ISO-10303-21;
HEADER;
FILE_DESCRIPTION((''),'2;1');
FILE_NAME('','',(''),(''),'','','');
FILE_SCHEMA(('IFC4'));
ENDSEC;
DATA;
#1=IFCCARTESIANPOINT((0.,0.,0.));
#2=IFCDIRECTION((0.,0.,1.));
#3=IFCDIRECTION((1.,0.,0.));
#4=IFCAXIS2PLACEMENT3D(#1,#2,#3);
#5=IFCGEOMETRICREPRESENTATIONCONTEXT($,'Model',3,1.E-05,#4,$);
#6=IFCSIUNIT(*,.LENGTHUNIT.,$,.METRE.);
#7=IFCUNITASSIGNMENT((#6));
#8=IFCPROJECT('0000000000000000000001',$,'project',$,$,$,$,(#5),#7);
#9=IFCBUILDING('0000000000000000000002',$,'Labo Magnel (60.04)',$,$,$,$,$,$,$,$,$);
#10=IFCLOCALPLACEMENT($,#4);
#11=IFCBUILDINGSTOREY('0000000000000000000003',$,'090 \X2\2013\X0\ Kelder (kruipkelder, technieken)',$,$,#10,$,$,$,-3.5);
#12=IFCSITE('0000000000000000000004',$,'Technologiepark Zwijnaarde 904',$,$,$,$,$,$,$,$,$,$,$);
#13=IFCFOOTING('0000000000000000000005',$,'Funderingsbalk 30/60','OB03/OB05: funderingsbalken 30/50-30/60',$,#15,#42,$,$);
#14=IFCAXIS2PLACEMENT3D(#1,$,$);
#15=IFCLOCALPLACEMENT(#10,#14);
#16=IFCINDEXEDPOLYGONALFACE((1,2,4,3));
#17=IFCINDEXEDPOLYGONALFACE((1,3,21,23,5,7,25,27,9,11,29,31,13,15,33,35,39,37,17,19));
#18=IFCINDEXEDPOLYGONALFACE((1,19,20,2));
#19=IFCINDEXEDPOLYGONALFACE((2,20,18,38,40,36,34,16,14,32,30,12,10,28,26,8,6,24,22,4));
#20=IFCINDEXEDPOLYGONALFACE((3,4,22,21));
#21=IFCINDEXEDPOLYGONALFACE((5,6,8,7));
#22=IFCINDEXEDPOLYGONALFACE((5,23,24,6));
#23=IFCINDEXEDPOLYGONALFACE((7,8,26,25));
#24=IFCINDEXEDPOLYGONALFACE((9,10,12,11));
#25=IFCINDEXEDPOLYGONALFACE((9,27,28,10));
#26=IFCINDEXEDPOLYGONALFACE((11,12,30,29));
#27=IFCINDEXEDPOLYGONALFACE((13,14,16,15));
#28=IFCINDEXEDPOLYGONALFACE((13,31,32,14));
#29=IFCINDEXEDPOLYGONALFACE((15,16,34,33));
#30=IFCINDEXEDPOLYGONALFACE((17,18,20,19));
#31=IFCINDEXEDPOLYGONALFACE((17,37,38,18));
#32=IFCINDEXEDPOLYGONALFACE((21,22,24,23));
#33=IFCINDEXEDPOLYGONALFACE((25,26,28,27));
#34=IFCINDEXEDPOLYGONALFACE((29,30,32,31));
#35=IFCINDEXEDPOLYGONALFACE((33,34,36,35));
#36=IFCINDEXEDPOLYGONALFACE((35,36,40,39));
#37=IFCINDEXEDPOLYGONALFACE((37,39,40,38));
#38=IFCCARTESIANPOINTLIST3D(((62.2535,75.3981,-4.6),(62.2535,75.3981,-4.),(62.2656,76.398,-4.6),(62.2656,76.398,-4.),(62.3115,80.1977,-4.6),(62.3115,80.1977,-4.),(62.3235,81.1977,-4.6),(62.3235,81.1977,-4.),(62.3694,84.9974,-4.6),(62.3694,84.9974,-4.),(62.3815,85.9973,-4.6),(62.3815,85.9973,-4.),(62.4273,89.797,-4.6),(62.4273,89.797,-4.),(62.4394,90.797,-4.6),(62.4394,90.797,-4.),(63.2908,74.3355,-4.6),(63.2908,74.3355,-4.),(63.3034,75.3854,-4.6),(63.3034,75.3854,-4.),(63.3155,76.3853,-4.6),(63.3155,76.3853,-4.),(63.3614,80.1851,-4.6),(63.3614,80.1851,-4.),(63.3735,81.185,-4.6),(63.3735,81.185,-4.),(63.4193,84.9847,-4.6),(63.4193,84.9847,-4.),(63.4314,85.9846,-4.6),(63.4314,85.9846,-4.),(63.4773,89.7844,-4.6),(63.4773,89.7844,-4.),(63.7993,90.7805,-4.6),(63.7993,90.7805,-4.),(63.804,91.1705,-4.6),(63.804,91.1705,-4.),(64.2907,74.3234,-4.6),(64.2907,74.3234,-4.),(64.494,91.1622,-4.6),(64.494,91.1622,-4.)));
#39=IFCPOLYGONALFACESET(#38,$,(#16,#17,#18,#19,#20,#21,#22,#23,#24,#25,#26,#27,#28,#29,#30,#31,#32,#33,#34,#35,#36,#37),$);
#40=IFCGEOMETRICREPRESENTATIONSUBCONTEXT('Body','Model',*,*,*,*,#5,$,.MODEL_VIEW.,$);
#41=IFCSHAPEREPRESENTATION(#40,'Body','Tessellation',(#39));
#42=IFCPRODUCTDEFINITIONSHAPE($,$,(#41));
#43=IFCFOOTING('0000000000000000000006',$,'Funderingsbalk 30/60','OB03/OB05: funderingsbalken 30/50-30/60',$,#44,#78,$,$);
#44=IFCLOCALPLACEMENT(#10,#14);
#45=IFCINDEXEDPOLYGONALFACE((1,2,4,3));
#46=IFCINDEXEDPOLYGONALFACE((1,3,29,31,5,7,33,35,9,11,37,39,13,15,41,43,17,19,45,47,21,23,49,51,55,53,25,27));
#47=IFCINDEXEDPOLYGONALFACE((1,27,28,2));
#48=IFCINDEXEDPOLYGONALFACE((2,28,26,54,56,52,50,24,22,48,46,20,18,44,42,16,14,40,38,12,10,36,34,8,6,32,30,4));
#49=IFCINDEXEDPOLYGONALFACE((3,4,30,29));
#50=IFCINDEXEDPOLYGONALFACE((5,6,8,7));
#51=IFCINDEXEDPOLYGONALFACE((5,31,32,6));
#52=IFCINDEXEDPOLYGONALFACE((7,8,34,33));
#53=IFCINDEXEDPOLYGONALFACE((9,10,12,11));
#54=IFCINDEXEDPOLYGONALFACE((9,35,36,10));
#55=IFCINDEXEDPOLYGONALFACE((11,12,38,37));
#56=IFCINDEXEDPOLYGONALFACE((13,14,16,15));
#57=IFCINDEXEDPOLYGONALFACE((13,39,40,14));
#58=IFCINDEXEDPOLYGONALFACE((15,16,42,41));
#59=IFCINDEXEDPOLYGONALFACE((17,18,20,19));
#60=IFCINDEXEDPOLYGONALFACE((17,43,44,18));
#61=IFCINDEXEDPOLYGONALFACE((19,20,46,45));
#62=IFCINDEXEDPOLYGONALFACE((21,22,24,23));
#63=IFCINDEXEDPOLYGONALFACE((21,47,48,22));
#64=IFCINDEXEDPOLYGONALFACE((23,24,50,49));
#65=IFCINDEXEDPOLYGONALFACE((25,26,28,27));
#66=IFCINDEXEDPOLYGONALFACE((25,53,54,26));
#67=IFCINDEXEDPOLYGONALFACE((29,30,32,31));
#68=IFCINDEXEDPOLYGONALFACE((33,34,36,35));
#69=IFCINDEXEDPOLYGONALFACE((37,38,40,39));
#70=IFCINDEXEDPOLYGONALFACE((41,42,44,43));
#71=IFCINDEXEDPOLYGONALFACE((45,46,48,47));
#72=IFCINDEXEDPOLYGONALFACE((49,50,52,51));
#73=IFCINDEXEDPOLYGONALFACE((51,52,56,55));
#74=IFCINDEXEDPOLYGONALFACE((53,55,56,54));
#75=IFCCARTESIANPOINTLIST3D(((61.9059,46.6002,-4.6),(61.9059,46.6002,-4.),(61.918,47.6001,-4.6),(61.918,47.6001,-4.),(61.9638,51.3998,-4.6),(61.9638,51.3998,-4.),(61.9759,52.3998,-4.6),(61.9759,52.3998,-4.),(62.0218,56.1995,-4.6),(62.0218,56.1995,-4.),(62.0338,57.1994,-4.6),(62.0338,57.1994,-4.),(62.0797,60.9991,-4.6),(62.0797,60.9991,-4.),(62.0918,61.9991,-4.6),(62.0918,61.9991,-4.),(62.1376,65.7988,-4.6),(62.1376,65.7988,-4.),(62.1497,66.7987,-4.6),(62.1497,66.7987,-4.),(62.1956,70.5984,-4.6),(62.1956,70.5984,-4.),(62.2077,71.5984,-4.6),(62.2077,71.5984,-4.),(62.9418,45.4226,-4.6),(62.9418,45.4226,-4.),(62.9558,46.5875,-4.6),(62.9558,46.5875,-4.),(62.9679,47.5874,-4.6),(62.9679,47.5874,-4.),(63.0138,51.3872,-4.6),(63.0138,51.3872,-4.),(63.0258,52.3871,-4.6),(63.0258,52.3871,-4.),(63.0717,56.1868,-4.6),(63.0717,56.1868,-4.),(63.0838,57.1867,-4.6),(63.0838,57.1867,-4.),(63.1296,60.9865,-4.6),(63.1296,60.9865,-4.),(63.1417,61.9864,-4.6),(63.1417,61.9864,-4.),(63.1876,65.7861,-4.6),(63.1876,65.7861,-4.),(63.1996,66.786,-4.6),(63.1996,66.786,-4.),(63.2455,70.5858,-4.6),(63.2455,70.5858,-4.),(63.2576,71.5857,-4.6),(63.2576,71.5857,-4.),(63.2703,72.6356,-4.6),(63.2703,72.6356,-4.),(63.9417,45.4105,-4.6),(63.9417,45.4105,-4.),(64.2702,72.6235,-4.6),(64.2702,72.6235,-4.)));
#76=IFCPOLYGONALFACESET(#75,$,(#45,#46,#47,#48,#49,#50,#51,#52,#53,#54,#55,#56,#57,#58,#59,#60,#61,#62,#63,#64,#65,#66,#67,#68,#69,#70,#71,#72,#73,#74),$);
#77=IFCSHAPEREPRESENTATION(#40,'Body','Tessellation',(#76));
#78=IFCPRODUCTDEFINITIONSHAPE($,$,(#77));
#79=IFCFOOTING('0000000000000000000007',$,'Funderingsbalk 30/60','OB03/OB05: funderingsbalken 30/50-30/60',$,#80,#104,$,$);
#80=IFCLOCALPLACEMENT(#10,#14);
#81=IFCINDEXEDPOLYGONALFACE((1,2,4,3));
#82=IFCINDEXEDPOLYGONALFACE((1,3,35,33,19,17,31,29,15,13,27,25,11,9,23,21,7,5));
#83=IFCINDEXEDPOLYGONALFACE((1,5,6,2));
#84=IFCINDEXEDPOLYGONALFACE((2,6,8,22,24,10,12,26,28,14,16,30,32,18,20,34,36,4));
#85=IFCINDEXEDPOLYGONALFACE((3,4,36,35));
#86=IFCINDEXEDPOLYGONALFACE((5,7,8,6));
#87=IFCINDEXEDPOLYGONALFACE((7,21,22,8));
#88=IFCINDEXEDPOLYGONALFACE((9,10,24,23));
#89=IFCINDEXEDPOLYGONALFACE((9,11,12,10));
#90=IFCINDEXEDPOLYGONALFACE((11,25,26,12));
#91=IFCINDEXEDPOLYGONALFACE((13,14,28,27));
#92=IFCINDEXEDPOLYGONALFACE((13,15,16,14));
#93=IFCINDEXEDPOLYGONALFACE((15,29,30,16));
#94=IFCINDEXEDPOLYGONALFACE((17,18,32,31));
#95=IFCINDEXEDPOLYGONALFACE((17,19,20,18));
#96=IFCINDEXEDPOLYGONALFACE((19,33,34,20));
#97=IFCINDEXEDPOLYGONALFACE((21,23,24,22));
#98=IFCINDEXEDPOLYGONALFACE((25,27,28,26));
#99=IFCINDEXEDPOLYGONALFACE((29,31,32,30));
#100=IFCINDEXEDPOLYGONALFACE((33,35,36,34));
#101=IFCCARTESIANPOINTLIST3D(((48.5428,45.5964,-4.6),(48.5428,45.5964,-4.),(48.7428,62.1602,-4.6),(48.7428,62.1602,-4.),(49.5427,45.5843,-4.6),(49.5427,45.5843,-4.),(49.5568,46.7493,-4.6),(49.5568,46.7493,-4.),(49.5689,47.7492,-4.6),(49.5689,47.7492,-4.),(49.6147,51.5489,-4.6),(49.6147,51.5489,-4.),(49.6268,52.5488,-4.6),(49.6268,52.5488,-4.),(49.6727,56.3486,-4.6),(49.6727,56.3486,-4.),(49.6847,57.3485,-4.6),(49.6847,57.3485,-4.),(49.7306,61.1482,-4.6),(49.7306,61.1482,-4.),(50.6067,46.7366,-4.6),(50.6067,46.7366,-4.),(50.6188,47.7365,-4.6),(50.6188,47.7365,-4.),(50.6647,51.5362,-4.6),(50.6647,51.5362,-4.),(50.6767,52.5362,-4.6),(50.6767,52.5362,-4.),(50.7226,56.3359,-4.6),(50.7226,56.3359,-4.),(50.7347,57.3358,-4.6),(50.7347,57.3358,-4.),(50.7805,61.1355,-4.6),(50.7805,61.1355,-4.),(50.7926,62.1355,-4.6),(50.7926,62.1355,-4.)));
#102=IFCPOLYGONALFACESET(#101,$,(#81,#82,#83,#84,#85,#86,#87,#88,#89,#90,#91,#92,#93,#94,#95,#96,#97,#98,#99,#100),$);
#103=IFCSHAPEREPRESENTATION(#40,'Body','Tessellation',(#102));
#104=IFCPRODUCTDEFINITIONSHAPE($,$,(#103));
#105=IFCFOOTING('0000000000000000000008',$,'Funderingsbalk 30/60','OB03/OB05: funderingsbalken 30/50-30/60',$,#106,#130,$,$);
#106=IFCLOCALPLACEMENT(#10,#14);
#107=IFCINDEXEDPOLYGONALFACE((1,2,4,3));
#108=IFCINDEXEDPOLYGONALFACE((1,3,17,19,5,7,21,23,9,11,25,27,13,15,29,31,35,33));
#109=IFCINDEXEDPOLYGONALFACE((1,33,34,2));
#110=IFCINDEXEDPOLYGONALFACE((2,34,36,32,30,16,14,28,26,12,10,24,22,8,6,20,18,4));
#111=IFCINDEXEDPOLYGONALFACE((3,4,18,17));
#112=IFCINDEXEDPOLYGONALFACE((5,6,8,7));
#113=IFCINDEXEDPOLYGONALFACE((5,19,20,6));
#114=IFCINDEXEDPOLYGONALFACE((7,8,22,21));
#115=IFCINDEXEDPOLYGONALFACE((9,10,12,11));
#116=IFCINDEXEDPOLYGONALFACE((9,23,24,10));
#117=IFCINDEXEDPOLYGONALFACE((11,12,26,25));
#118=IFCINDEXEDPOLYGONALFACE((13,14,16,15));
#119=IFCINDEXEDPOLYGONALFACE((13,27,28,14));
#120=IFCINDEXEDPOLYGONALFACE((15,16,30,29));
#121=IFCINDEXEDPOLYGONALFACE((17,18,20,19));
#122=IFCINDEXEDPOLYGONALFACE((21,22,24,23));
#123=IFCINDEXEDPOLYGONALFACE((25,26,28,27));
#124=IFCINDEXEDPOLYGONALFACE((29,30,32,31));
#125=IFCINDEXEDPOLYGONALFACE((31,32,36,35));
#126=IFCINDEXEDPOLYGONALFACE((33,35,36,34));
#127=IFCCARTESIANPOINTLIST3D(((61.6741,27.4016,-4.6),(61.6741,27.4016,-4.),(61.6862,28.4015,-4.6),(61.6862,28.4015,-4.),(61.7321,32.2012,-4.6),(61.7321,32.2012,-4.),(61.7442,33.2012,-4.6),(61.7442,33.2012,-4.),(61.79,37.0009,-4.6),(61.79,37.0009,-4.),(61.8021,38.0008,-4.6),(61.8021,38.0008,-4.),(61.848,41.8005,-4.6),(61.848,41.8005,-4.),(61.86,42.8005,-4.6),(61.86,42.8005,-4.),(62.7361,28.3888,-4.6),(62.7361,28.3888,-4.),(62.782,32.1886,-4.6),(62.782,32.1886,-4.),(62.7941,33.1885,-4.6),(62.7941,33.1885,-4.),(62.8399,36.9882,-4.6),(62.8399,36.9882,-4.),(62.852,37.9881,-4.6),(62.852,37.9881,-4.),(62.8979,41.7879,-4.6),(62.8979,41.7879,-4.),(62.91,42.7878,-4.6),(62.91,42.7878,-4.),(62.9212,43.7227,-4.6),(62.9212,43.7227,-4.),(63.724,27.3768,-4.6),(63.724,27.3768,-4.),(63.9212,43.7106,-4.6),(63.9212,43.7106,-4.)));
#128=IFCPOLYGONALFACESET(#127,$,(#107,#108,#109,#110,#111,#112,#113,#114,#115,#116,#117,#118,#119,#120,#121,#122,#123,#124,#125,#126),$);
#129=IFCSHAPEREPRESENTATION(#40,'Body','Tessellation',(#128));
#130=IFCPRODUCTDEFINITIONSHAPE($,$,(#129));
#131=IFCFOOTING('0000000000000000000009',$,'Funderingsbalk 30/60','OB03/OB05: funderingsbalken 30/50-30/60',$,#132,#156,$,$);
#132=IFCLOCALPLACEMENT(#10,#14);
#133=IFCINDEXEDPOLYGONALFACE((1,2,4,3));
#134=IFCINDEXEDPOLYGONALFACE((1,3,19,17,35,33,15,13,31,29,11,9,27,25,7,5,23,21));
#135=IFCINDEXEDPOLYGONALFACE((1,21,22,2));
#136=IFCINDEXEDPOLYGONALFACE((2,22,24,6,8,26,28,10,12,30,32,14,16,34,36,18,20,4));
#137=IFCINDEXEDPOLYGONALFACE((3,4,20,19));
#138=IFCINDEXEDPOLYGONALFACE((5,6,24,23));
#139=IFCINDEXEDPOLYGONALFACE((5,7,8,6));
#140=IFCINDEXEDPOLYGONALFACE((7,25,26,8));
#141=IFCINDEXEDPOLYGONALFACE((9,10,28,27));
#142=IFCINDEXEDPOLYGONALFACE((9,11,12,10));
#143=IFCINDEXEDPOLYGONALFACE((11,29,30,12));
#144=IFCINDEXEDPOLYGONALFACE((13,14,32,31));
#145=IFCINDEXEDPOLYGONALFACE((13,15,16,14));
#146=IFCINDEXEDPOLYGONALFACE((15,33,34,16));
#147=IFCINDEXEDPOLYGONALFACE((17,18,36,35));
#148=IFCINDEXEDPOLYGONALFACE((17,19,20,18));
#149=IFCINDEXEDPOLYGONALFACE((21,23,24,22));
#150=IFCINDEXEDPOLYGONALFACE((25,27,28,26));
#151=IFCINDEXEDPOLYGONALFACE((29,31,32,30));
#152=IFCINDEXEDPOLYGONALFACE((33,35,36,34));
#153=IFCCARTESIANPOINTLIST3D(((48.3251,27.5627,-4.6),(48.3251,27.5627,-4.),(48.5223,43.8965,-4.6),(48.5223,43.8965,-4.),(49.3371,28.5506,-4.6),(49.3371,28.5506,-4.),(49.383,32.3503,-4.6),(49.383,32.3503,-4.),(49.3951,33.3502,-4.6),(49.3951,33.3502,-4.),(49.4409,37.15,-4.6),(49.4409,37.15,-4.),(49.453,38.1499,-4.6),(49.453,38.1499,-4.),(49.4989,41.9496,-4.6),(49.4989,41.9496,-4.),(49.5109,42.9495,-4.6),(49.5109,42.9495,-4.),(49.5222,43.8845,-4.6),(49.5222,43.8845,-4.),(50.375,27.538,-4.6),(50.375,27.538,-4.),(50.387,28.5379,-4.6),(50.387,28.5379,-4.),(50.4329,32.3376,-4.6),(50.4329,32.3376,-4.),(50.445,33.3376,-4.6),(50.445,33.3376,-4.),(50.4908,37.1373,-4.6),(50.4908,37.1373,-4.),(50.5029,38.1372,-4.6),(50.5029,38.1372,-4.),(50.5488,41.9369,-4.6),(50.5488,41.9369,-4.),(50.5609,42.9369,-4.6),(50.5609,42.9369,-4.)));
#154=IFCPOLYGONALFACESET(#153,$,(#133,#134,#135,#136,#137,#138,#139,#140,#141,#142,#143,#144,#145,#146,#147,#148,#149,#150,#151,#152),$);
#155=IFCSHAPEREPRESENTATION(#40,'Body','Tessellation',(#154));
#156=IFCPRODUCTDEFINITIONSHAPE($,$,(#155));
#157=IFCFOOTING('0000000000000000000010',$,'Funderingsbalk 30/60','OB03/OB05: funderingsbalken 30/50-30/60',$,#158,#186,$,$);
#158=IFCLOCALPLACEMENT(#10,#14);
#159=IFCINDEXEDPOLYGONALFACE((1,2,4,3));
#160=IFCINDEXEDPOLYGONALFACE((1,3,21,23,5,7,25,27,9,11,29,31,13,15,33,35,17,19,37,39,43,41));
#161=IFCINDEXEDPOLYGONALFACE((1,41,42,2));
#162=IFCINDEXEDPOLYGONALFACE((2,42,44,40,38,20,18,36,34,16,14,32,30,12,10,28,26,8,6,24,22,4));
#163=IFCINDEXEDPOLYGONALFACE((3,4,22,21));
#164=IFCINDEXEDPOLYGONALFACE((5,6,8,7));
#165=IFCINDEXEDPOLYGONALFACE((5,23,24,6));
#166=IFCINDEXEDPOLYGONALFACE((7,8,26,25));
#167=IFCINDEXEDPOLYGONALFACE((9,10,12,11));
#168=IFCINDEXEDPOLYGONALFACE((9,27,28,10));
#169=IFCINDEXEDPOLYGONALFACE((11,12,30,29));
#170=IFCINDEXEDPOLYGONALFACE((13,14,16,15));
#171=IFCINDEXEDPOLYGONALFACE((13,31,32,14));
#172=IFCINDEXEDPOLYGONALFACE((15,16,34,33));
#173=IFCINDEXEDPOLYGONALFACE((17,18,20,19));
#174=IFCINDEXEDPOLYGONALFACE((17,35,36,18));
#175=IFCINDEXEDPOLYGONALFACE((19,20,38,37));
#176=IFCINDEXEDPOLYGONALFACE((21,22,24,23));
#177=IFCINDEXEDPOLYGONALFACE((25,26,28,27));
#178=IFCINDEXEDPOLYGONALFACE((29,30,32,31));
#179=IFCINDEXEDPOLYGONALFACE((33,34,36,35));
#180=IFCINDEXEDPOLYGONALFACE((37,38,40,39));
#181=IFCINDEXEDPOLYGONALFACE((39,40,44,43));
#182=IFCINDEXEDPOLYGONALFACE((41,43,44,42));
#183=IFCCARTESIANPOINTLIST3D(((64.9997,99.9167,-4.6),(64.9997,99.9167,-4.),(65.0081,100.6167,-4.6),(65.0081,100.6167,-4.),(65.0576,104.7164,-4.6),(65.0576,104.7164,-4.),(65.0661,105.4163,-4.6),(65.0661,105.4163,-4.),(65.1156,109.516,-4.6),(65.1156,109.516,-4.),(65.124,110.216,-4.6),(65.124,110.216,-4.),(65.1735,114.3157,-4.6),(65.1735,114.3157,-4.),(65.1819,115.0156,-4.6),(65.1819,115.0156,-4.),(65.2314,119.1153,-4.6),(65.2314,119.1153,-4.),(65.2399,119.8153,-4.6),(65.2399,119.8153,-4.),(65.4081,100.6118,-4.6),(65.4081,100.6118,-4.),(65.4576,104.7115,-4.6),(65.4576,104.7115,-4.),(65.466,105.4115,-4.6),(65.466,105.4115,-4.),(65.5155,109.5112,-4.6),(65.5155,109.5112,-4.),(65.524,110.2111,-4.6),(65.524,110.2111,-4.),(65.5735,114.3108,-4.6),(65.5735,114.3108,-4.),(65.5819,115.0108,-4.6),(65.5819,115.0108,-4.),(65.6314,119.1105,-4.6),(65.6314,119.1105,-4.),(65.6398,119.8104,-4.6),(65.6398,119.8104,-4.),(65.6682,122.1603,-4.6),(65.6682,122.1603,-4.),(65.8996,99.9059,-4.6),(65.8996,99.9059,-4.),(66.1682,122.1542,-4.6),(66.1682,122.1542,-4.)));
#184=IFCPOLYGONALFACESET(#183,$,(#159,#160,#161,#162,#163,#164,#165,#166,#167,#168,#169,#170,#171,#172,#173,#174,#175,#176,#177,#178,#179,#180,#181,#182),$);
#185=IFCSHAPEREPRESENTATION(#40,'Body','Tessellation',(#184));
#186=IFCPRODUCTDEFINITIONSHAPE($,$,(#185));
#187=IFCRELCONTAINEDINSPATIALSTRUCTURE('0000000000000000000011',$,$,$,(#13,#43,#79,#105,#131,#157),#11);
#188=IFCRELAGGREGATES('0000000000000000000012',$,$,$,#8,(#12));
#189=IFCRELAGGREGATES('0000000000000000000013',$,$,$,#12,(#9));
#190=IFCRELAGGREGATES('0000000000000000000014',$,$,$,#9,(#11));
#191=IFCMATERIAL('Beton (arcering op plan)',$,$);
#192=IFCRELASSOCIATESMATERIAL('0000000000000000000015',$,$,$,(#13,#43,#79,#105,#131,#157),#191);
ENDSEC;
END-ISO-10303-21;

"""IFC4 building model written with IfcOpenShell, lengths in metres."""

from ifc_helpers import new_model, si_unit, frame, origin, origin_with_axes, place, context, subcontext, project, spatial, polyline, outline, extrude, material, element, save


model = new_model("IFC4")

# Units and contexts
model_context = context("Model", 3, precision=1e-05, world=origin_with_axes())
body_context = subcontext(model_context, "Body", "Model", "MODEL_VIEW")
ifc_project = project(units=[si_unit("LENGTHUNIT", "METRE")], contexts=[model_context])

# Site, building, storey
site = spatial("IfcSite", under=ifc_project, Name="Technologiepark Zwijnaarde 904")
building = spatial("IfcBuilding", under=site, Name="Labo Magnel (60.04)")
storey_placement = place(None, origin_with_axes())
storey = spatial("IfcBuildingStorey", under=building, at=storey_placement, Name="090 – Kelder (kruipkelder, technieken)", Elevation=-3.5)

# Footings
ifc_material_1 = material(Name="Beton (arcering op plan)")
footing_1_placement = place(storey_placement, frame((0.0, 0.0, -4.6), z_axis=(0.0, 0.0, 1.0), x_axis=(1.0, 0.0, 0.0)))
element("IfcFooting", 1, at=footing_1_placement, inside=storey, material=ifc_material_1, Name="Funderingsbalk 30/60", Description="OB03/OB05: funderingsbalken 30/50-30/60", context=body_context, shape_type="SweptSolid", body=[
    extrude(outline(polyline([(64.494, 91.1622), (64.2907, 74.3234), (63.2908, 74.3355), (63.3034, 75.3854), (62.2535, 75.3981), (62.2656, 76.398), (63.3155, 76.3853), (63.3614, 80.1851), (62.3115, 80.1977), (62.3235, 81.1977), (63.3735, 81.185), (63.4193, 84.9847), (62.3694, 84.9974), (62.3815, 85.9973), (63.4314, 85.9846), (63.4773, 89.7844), (62.4273, 89.797), (62.4394, 90.797), (63.7993, 90.7805), (63.804, 91.1705), (64.494, 91.1622)])), origin(), (0.0, 0.0, 1.0), 0.6),
])
footing_2_placement = place(storey_placement, frame((0.0, 0.0, -4.6), z_axis=(0.0, 0.0, 1.0), x_axis=(1.0, 0.0, 0.0)))
element("IfcFooting", 2, at=footing_2_placement, inside=storey, material=ifc_material_1, Name="Funderingsbalk 30/60", Description="OB03/OB05: funderingsbalken 30/50-30/60", context=body_context, shape_type="SweptSolid", body=[
    extrude(outline(polyline([(64.2702, 72.6235), (63.9417, 45.4105), (62.9418, 45.4226), (62.9558, 46.5875), (61.9059, 46.6002), (61.918, 47.6001), (62.9679, 47.5874), (63.0138, 51.3872), (61.9638, 51.3998), (61.9759, 52.3998), (63.0258, 52.3871), (63.0717, 56.1868), (62.0218, 56.1995), (62.0338, 57.1994), (63.0838, 57.1867), (63.1296, 60.9865), (62.0797, 60.9991), (62.0918, 61.9991), (63.1417, 61.9864), (63.1876, 65.7861), (62.1376, 65.7988), (62.1497, 66.7987), (63.1996, 66.786), (63.2455, 70.5858), (62.1956, 70.5984), (62.2077, 71.5984), (63.2576, 71.5857), (63.2703, 72.6356), (64.2702, 72.6235)])), origin(), (0.0, 0.0, 1.0), 0.6),
])
footing_3_placement = place(storey_placement, frame((0.0, 0.0, -4.6), z_axis=(0.0, 0.0, 1.0), x_axis=(1.0, 0.0, 0.0)))
element("IfcFooting", 3, at=footing_3_placement, inside=storey, material=ifc_material_1, Name="Funderingsbalk 30/60", Description="OB03/OB05: funderingsbalken 30/50-30/60", context=body_context, shape_type="SweptSolid", body=[
    extrude(outline(polyline([(50.6188, 47.7365), (50.6067, 46.7366), (49.5568, 46.7493), (49.5427, 45.5843), (48.5428, 45.5964), (48.7428, 62.1602), (50.7926, 62.1355), (50.7805, 61.1355), (49.7306, 61.1482), (49.6847, 57.3485), (50.7347, 57.3358), (50.7226, 56.3359), (49.6727, 56.3486), (49.6268, 52.5488), (50.6767, 52.5362), (50.6647, 51.5362), (49.6147, 51.5489), (49.5689, 47.7492), (50.6188, 47.7365)])), origin(), (0.0, 0.0, 1.0), 0.6),
])
footing_4_placement = place(storey_placement, frame((0.0, 0.0, -4.6), z_axis=(0.0, 0.0, 1.0), x_axis=(1.0, 0.0, 0.0)))
element("IfcFooting", 4, at=footing_4_placement, inside=storey, material=ifc_material_1, Name="Funderingsbalk 30/60", Description="OB03/OB05: funderingsbalken 30/50-30/60", context=body_context, shape_type="SweptSolid", body=[
    extrude(outline(polyline([(63.9212, 43.7106), (63.724, 27.3768), (61.6741, 27.4016), (61.6862, 28.4015), (62.7361, 28.3888), (62.782, 32.1886), (61.7321, 32.2012), (61.7442, 33.2012), (62.7941, 33.1885), (62.8399, 36.9882), (61.79, 37.0009), (61.8021, 38.0008), (62.852, 37.9881), (62.8979, 41.7879), (61.848, 41.8005), (61.86, 42.8005), (62.91, 42.7878), (62.9212, 43.7227), (63.9212, 43.7106)])), origin(), (0.0, 0.0, 1.0), 0.6),
])
footing_5_placement = place(storey_placement, frame((0.0, 0.0, -4.6), z_axis=(0.0, 0.0, 1.0), x_axis=(1.0, 0.0, 0.0)))
element("IfcFooting", 5, at=footing_5_placement, inside=storey, material=ifc_material_1, Name="Funderingsbalk 30/60", Description="OB03/OB05: funderingsbalken 30/50-30/60", context=body_context, shape_type="SweptSolid", body=[
    extrude(outline(polyline([(49.383, 32.3503), (49.3371, 28.5506), (50.387, 28.5379), (50.375, 27.538), (48.3251, 27.5627), (48.5223, 43.8965), (49.5222, 43.8845), (49.5109, 42.9495), (50.5609, 42.9369), (50.5488, 41.9369), (49.4989, 41.9496), (49.453, 38.1499), (50.5029, 38.1372), (50.4908, 37.1373), (49.4409, 37.15), (49.3951, 33.3502), (50.445, 33.3376), (50.4329, 32.3376), (49.383, 32.3503)])), origin(), (0.0, 0.0, 1.0), 0.6),
])
footing_6_placement = place(storey_placement, frame((0.0, 0.0, -4.6), z_axis=(0.0, 0.0, 1.0), x_axis=(1.0, 0.0, 0.0)))
element("IfcFooting", 6, at=footing_6_placement, inside=storey, material=ifc_material_1, Name="Funderingsbalk 30/60", Description="OB03/OB05: funderingsbalken 30/50-30/60", context=body_context, shape_type="SweptSolid", body=[
    extrude(outline(polyline([(66.1682, 122.1542), (65.8996, 99.9059), (64.9997, 99.9167), (65.0081, 100.6167), (65.4081, 100.6118), (65.4576, 104.7115), (65.0576, 104.7164), (65.0661, 105.4163), (65.466, 105.4115), (65.5155, 109.5112), (65.1156, 109.516), (65.124, 110.216), (65.524, 110.2111), (65.5735, 114.3108), (65.1735, 114.3157), (65.1819, 115.0156), (65.5819, 115.0108), (65.6314, 119.1105), (65.2314, 119.1153), (65.2399, 119.8153), (65.6398, 119.8104), (65.6682, 122.1603), (66.1682, 122.1542)])), origin(), (0.0, 0.0, 1.0), 0.6),
])

save(model, "model.ifc")
